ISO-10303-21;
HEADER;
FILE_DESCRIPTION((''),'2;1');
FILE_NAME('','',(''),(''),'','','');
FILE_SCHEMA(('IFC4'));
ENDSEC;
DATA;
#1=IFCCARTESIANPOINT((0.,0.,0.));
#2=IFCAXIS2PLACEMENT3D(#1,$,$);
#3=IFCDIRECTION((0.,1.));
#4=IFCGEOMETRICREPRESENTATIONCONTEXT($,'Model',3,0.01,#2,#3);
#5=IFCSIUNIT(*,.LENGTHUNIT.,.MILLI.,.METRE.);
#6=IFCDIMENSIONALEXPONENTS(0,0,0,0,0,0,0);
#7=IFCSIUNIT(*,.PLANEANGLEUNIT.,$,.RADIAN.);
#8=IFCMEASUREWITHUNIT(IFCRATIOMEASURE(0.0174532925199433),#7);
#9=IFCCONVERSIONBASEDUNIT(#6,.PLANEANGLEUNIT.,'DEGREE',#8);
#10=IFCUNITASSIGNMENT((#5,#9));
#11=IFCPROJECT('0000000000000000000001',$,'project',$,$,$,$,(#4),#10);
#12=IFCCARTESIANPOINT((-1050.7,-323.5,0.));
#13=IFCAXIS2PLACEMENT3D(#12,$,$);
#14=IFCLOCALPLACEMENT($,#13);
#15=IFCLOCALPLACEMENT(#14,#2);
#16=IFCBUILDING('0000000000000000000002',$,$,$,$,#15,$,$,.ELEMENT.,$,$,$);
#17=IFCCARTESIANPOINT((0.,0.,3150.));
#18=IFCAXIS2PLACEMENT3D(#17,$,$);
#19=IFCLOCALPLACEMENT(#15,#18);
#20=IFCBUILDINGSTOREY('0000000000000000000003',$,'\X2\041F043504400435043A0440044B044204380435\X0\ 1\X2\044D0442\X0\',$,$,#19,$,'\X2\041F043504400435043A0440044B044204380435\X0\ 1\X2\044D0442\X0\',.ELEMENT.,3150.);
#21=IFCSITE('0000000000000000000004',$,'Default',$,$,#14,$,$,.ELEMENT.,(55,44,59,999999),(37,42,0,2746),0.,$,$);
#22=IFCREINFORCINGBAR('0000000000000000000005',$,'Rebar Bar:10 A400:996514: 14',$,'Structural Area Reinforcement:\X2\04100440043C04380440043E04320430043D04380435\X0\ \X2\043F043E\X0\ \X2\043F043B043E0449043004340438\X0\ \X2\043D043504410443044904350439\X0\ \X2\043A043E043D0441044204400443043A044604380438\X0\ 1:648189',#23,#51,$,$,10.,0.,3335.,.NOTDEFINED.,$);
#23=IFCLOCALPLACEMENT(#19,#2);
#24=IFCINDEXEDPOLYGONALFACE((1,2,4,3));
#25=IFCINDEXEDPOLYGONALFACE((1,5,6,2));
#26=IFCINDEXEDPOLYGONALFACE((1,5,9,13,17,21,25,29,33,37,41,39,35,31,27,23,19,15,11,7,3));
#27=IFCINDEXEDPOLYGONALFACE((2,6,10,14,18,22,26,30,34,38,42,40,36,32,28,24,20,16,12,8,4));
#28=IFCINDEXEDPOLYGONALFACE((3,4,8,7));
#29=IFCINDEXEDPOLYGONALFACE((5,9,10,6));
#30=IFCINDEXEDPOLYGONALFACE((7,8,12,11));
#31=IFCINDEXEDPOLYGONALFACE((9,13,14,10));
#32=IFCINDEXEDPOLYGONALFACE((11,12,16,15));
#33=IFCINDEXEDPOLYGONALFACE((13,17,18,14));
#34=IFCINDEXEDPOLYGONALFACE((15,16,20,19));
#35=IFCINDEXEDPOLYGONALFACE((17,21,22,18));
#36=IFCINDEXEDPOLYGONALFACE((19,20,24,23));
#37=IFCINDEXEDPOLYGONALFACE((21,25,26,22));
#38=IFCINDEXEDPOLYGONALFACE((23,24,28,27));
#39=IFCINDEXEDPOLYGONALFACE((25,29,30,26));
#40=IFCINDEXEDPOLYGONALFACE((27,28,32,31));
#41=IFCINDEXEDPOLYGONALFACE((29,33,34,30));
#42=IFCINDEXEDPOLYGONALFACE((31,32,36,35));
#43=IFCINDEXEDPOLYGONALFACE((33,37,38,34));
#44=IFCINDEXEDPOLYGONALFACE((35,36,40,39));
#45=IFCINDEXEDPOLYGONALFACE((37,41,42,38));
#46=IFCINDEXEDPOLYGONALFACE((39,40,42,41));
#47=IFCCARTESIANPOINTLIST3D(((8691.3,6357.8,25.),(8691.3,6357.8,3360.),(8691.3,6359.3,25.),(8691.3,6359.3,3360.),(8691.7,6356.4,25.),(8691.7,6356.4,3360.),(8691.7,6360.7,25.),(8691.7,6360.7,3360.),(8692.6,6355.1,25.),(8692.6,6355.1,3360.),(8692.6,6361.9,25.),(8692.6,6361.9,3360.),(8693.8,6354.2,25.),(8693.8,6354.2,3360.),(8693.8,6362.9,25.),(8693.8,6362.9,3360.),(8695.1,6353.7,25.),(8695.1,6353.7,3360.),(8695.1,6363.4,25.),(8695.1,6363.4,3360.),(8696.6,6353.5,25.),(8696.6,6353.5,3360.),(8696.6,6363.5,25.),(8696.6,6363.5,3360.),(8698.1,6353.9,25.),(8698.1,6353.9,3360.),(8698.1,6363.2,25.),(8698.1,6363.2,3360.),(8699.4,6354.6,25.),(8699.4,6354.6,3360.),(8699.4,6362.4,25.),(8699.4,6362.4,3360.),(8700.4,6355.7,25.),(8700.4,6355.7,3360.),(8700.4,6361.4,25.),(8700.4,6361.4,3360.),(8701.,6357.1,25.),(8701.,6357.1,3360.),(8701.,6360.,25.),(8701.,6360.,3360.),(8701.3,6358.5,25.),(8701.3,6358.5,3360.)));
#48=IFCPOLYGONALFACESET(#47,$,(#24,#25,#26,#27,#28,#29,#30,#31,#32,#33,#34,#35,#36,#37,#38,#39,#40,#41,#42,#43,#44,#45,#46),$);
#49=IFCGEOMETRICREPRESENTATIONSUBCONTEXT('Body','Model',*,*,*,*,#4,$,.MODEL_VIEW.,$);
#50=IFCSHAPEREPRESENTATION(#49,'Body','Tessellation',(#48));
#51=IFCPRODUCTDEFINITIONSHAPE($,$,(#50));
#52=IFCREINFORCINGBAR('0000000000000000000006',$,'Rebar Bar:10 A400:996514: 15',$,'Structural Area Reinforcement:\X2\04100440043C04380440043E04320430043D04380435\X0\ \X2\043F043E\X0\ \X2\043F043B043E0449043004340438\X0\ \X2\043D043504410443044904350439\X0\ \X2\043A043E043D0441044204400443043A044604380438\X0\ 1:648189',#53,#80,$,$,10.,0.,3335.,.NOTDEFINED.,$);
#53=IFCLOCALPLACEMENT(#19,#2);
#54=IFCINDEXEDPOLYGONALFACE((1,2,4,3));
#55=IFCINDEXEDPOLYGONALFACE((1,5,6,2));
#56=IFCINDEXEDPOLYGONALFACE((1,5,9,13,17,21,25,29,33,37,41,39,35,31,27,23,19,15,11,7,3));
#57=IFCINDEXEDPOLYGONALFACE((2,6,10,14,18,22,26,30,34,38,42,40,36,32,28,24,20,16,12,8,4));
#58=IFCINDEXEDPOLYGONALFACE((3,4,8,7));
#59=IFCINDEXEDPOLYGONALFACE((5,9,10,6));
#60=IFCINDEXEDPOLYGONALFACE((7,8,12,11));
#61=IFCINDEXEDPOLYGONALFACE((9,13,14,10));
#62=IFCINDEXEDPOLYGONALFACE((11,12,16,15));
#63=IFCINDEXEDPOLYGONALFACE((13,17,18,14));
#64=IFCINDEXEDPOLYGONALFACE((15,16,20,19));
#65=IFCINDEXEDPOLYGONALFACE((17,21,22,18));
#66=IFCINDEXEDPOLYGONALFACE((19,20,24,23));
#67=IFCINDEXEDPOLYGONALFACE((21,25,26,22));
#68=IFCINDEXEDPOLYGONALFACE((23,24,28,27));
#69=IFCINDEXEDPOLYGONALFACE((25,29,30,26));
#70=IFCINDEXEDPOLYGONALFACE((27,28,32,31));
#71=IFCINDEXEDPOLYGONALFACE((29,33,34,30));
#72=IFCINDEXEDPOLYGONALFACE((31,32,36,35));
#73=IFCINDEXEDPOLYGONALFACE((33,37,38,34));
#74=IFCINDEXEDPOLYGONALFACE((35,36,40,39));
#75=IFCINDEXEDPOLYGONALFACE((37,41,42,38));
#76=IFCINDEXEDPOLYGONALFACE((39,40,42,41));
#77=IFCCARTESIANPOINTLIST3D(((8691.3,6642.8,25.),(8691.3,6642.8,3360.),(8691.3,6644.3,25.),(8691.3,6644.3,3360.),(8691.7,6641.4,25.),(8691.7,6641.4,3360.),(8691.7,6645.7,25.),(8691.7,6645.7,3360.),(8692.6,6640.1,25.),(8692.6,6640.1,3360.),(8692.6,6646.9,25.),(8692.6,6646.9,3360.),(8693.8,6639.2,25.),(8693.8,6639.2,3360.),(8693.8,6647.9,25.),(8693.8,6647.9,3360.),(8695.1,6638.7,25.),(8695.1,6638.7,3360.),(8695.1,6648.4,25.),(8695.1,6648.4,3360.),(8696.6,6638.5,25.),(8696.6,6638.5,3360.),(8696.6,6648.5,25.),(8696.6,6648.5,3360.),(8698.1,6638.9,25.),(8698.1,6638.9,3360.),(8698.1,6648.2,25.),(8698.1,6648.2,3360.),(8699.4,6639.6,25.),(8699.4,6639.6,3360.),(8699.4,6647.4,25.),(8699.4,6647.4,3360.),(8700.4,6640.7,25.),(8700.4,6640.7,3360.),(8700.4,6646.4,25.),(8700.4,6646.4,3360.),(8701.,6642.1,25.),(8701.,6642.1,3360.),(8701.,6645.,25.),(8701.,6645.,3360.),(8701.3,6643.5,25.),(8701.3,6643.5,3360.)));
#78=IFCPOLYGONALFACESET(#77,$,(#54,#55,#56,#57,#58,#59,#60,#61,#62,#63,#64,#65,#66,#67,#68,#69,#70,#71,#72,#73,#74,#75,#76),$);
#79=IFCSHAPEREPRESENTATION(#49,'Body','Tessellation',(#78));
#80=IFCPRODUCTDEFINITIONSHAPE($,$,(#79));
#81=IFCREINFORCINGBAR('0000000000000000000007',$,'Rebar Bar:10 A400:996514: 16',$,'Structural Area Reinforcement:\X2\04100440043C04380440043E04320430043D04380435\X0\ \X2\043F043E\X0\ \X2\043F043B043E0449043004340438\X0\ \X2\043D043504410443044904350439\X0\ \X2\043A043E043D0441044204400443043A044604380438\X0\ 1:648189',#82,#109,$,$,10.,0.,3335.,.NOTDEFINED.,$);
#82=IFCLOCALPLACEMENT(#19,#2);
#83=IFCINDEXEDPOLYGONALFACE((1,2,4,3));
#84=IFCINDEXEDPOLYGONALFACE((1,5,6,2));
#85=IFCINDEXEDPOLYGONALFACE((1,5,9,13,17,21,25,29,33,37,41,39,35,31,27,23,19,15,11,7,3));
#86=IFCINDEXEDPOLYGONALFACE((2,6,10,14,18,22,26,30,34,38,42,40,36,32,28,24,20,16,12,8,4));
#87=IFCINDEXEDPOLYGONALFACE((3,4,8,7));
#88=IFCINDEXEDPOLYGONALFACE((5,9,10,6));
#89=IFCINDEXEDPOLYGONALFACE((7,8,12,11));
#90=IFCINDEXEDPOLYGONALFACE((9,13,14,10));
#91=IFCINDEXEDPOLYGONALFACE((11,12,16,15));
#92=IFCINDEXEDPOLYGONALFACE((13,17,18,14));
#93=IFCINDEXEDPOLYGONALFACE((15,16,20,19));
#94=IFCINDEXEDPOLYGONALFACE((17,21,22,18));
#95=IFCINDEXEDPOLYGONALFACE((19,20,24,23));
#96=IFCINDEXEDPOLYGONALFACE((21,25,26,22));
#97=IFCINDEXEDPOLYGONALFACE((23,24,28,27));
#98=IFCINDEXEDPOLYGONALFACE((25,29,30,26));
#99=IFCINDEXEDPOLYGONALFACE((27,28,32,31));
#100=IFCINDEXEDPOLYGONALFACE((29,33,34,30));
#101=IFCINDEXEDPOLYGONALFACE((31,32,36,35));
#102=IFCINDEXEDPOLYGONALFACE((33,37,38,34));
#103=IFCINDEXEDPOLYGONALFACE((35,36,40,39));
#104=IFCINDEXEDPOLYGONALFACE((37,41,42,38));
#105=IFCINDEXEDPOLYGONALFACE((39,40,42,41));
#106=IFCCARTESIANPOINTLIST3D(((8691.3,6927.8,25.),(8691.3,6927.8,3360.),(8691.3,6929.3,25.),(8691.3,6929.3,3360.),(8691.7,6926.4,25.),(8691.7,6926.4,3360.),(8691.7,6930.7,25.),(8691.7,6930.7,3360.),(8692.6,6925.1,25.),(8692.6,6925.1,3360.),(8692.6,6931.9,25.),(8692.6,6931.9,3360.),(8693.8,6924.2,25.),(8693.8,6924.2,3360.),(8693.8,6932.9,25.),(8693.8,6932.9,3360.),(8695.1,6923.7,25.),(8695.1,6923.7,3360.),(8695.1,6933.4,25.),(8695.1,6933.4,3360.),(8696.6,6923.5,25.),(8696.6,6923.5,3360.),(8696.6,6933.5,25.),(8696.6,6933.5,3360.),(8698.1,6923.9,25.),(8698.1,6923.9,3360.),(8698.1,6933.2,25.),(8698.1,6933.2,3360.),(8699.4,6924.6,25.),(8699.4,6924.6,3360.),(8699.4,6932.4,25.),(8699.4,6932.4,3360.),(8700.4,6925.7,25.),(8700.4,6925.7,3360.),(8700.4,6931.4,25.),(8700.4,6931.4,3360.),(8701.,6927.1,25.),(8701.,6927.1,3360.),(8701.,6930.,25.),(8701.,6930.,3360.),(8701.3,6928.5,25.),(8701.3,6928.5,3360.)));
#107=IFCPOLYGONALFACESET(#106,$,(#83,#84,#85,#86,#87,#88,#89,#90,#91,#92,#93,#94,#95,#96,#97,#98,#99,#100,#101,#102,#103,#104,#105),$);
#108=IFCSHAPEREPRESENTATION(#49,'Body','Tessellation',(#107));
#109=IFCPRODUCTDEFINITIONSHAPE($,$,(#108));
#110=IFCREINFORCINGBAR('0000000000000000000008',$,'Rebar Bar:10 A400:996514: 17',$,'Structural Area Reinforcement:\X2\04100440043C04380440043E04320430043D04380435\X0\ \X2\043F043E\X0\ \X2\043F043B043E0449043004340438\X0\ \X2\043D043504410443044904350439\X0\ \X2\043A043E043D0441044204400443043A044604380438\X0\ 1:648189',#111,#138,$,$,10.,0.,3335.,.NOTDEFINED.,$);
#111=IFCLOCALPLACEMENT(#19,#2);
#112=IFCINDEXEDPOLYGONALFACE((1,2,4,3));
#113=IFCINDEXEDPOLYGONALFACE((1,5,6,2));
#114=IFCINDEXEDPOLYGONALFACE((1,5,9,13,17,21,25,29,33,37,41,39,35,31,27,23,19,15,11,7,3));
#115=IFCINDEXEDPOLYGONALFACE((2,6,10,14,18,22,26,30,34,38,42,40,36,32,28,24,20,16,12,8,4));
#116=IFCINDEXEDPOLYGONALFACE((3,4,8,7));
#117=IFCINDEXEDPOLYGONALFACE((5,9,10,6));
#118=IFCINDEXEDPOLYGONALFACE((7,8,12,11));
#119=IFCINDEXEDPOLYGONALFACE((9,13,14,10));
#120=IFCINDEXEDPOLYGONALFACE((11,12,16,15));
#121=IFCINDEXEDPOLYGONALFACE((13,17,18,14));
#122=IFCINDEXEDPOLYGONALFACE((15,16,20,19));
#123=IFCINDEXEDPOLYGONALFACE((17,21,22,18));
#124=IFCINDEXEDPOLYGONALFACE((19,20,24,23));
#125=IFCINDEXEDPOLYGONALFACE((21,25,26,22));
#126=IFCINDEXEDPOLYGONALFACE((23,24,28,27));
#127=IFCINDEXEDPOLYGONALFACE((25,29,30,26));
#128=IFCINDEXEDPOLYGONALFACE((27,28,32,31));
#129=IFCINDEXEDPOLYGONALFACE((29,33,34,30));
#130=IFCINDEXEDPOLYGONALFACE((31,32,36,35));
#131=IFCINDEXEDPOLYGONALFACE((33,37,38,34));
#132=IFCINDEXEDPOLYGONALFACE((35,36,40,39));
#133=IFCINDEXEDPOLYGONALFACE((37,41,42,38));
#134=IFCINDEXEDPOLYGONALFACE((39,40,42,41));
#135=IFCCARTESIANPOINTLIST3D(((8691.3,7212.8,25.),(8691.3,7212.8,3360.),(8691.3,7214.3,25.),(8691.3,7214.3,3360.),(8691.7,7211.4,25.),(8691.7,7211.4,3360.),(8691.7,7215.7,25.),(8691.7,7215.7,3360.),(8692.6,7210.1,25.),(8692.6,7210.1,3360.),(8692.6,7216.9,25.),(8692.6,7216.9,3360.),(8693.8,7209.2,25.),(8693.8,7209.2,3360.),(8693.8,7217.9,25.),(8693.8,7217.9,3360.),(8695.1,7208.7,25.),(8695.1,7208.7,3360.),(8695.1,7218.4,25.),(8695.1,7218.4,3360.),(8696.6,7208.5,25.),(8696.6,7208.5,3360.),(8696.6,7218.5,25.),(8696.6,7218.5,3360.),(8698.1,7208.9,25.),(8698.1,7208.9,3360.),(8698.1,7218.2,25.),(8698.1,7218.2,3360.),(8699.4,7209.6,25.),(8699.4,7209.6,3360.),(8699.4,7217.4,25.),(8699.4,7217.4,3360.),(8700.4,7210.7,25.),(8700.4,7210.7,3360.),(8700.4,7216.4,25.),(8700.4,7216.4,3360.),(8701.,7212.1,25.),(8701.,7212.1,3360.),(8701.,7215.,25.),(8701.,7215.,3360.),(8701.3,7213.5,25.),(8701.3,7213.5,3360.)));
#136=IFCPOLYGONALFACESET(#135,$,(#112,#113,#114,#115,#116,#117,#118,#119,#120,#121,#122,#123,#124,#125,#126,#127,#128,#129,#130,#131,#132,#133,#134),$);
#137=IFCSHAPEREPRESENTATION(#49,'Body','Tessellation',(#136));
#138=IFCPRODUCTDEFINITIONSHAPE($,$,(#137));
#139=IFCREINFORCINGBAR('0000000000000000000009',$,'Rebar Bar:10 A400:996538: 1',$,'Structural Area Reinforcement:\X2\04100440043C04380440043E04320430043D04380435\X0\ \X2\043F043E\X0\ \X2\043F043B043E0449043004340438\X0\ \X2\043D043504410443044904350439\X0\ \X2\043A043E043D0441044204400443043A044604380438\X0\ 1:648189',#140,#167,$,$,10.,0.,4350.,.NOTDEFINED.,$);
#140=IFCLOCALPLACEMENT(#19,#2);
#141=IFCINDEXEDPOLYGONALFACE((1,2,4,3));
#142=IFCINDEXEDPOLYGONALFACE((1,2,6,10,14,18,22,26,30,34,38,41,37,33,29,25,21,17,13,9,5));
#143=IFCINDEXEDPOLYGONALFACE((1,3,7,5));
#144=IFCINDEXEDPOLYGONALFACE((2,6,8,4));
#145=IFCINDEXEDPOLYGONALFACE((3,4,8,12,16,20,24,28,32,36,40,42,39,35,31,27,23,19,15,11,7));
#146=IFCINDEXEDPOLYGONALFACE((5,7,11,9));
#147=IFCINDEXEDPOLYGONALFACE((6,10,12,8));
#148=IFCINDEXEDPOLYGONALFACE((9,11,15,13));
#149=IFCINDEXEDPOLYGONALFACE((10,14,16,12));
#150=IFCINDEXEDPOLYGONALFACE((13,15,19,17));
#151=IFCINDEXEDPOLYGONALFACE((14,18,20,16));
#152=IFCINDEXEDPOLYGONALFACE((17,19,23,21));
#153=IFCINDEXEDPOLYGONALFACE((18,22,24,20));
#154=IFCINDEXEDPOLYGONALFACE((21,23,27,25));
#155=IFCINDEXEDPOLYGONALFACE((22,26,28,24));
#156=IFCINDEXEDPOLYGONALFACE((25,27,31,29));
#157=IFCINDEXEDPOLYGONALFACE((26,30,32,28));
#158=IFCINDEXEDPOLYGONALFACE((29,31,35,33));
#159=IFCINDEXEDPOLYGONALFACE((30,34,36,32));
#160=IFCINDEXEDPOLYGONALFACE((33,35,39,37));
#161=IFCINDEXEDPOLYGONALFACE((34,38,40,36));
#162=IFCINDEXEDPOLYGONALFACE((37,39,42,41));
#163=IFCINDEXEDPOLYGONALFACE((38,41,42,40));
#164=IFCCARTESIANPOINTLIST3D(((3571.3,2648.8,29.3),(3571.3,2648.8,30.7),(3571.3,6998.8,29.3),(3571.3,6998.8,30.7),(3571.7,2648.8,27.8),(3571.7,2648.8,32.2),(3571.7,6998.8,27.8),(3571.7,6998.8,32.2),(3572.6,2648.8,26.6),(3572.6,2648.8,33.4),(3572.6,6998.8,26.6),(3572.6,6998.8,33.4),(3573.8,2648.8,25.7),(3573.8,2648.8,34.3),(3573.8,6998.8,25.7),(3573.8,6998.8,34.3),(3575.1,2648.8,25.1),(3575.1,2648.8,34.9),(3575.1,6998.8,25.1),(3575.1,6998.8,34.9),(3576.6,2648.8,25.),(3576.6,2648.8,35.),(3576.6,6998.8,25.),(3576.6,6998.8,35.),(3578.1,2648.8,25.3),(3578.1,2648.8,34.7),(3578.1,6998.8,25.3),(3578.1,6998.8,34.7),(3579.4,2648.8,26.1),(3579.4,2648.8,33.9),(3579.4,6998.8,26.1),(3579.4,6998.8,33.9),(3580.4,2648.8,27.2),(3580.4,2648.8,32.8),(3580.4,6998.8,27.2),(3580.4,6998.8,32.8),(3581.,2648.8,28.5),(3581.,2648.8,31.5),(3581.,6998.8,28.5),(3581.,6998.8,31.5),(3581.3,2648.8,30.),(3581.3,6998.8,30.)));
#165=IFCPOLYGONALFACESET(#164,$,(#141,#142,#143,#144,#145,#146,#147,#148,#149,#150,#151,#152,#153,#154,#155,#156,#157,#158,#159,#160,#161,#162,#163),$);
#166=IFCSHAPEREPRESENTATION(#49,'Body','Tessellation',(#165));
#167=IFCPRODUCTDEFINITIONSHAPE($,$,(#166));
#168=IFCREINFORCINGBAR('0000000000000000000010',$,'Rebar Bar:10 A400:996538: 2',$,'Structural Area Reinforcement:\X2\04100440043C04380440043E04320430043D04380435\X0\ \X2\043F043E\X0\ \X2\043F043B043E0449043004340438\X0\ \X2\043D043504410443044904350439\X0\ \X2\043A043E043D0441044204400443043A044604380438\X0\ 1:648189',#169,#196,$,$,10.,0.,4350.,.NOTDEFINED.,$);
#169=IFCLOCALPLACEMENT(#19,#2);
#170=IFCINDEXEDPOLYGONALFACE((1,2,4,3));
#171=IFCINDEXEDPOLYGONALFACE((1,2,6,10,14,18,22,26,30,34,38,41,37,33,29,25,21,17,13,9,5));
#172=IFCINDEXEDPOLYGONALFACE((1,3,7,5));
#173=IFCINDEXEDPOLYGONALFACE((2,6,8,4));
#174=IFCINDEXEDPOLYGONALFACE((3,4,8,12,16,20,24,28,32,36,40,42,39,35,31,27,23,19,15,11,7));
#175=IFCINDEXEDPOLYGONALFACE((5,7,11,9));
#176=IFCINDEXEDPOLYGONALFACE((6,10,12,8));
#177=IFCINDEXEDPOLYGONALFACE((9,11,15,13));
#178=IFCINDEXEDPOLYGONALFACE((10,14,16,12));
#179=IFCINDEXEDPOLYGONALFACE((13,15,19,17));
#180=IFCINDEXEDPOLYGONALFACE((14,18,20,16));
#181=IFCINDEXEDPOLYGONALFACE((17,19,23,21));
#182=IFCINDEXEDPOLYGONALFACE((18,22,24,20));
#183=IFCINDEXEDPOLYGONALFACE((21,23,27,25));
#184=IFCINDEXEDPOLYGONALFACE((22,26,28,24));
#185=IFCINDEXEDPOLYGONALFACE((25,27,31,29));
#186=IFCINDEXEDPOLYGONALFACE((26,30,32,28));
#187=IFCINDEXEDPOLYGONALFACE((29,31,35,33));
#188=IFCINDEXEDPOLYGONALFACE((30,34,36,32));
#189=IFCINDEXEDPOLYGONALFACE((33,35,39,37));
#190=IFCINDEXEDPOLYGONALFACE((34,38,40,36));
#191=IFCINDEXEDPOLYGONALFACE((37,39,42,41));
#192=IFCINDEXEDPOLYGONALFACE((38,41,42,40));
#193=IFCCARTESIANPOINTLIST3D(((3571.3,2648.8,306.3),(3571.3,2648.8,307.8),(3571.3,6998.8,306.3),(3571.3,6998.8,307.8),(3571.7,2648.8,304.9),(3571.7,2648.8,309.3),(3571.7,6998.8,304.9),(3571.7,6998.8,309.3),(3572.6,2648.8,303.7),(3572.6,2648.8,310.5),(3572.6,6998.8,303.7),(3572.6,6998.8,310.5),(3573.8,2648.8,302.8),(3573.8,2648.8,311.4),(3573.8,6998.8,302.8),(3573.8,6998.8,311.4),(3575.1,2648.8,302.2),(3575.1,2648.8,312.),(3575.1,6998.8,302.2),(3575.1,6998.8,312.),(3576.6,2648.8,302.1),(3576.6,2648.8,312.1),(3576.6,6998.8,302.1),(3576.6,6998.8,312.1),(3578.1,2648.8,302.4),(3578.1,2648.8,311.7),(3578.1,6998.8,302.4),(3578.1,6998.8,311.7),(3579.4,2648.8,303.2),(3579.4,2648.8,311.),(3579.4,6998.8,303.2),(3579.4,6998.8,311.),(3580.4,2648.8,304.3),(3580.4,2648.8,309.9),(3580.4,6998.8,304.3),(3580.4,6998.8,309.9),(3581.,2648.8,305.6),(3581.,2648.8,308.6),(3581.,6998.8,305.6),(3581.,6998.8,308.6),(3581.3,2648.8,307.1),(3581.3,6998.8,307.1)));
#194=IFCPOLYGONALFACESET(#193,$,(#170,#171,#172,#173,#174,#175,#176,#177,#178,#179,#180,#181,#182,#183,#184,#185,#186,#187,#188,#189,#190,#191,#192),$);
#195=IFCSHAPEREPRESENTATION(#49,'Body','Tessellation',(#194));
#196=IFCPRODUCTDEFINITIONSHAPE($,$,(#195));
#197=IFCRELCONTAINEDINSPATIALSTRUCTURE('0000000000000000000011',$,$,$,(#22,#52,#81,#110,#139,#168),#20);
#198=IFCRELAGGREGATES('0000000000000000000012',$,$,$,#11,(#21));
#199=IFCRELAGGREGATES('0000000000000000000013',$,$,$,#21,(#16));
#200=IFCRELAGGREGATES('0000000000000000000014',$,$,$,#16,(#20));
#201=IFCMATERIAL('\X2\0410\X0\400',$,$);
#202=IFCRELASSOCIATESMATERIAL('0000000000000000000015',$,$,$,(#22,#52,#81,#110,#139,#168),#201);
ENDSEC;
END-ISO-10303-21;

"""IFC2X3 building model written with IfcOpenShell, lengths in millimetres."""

from ifc_helpers import new_model, entity, si_unit, converted_unit, direction, frame, origin, place, context, subcontext, project, spatial, material, element, save


model = new_model("IFC2X3")

# Units and contexts
model_context = context("Model", 3, precision=0.01, world=origin(), true_north=direction((0.0, 1.0)))
body_context = subcontext(model_context, "Body", "Model", "MODEL_VIEW")
ifc_project = project(units=[si_unit("LENGTHUNIT", "METRE", prefix="MILLI"), converted_unit("PLANEANGLEUNIT", "DEGREE", entity("IfcRatioMeasure", 0.0174532925199433), si_unit("PLANEANGLEUNIT", "RADIAN"), dimensions=[0, 0, 0, 0, 0, 0, 0])], contexts=[model_context])

# Site, building, storey
site_placement = place(None, frame((-1050.7, -323.5, 0.0)))
site = spatial("IfcSite", under=ifc_project, at=site_placement, Name="Default", CompositionType="ELEMENT", RefLatitude=(55, 44, 59, 999999), RefLongitude=(37, 42, 0, 2746), RefElevation=0.0)
building_placement = place(site_placement, origin())
building = spatial("IfcBuilding", under=site, at=building_placement, CompositionType="ELEMENT")
storey_placement = place(building_placement, frame((0.0, 0.0, 3150.0)))
storey = spatial("IfcBuildingStorey", under=building, at=storey_placement, Name="Перекрытие 1эт", LongName="Перекрытие 1эт", CompositionType="ELEMENT", Elevation=3150.0)

# Reinforcing bars
ifc_material = material(Name="А400")
reinforcing_bar_1_placement = place(storey_placement, origin())
element("IfcReinforcingBar", 1, at=reinforcing_bar_1_placement, inside=storey, material=ifc_material, Name="Rebar Bar:10 A400:996514: 14", ObjectType="Structural Area Reinforcement:Армирование по площади несущей конструкции 1:648189", BarLength=3335.0, BarRole="NOTDEFINED", CrossSectionArea=0.0, NominalDiameter=10.0, context=body_context, shape_type="AdvancedSweptSolid", body=[
    entity("IfcSweptDiskSolid", entity("IfcCompositeCurve", [entity("IfcCompositeCurveSegment", "CONTINUOUS", True, entity("IfcPolyline", [entity("IfcCartesianPoint", [8696.3, 6358.5, 25.0]), entity("IfcCartesianPoint", [8696.3, 6358.5, 3360.0])]))], False), 5.0, None, 0.0, 1.0),
])
reinforcing_bar_2_placement = place(storey_placement, origin())
element("IfcReinforcingBar", 2, at=reinforcing_bar_2_placement, inside=storey, material=ifc_material, Name="Rebar Bar:10 A400:996514: 15", ObjectType="Structural Area Reinforcement:Армирование по площади несущей конструкции 1:648189", BarLength=3335.0, BarRole="NOTDEFINED", CrossSectionArea=0.0, NominalDiameter=10.0, context=body_context, shape_type="AdvancedSweptSolid", body=[
    entity("IfcSweptDiskSolid", entity("IfcCompositeCurve", [entity("IfcCompositeCurveSegment", "CONTINUOUS", True, entity("IfcPolyline", [entity("IfcCartesianPoint", [8696.3, 6643.5, 25.0]), entity("IfcCartesianPoint", [8696.3, 6643.5, 3360.0])]))], False), 5.0, None, 0.0, 1.0),
])
reinforcing_bar_3_placement = place(storey_placement, origin())
element("IfcReinforcingBar", 3, at=reinforcing_bar_3_placement, inside=storey, material=ifc_material, Name="Rebar Bar:10 A400:996514: 16", ObjectType="Structural Area Reinforcement:Армирование по площади несущей конструкции 1:648189", BarLength=3335.0, BarRole="NOTDEFINED", CrossSectionArea=0.0, NominalDiameter=10.0, context=body_context, shape_type="AdvancedSweptSolid", body=[
    entity("IfcSweptDiskSolid", entity("IfcCompositeCurve", [entity("IfcCompositeCurveSegment", "CONTINUOUS", True, entity("IfcPolyline", [entity("IfcCartesianPoint", [8696.3, 6928.5, 25.0]), entity("IfcCartesianPoint", [8696.3, 6928.5, 3360.0])]))], False), 5.0, None, 0.0, 1.0),
])
reinforcing_bar_4_placement = place(storey_placement, origin())
element("IfcReinforcingBar", 4, at=reinforcing_bar_4_placement, inside=storey, material=ifc_material, Name="Rebar Bar:10 A400:996514: 17", ObjectType="Structural Area Reinforcement:Армирование по площади несущей конструкции 1:648189", BarLength=3335.0, BarRole="NOTDEFINED", CrossSectionArea=0.0, NominalDiameter=10.0, context=body_context, shape_type="AdvancedSweptSolid", body=[
    entity("IfcSweptDiskSolid", entity("IfcCompositeCurve", [entity("IfcCompositeCurveSegment", "CONTINUOUS", True, entity("IfcPolyline", [entity("IfcCartesianPoint", [8696.3, 7213.5, 25.0]), entity("IfcCartesianPoint", [8696.3, 7213.5, 3360.0])]))], False), 5.0, None, 0.0, 1.0),
])
reinforcing_bar_5_placement = place(storey_placement, origin())
element("IfcReinforcingBar", 5, at=reinforcing_bar_5_placement, inside=storey, material=ifc_material, Name="Rebar Bar:10 A400:996538: 1", ObjectType="Structural Area Reinforcement:Армирование по площади несущей конструкции 1:648189", BarLength=4350.0, BarRole="NOTDEFINED", CrossSectionArea=0.0, NominalDiameter=10.0, context=body_context, shape_type="AdvancedSweptSolid", body=[
    entity("IfcSweptDiskSolid", entity("IfcCompositeCurve", [entity("IfcCompositeCurveSegment", "CONTINUOUS", True, entity("IfcPolyline", [entity("IfcCartesianPoint", [3576.3, 2648.8, 30.0]), entity("IfcCartesianPoint", [3576.3, 6998.8, 30.0])]))], False), 5.0, None, 0.0, 1.0),
])
reinforcing_bar_6_placement = place(storey_placement, origin())
element("IfcReinforcingBar", 6, at=reinforcing_bar_6_placement, inside=storey, material=ifc_material, Name="Rebar Bar:10 A400:996538: 2", ObjectType="Structural Area Reinforcement:Армирование по площади несущей конструкции 1:648189", BarLength=4350.0, BarRole="NOTDEFINED", CrossSectionArea=0.0, NominalDiameter=10.0, context=body_context, shape_type="AdvancedSweptSolid", body=[
    entity("IfcSweptDiskSolid", entity("IfcCompositeCurve", [entity("IfcCompositeCurveSegment", "CONTINUOUS", True, entity("IfcPolyline", [entity("IfcCartesianPoint", [3576.3, 2648.8, 307.1]), entity("IfcCartesianPoint", [3576.3, 6998.8, 307.1])]))], False), 5.0, None, 0.0, 1.0),
])

save(model, "model.ifc")
